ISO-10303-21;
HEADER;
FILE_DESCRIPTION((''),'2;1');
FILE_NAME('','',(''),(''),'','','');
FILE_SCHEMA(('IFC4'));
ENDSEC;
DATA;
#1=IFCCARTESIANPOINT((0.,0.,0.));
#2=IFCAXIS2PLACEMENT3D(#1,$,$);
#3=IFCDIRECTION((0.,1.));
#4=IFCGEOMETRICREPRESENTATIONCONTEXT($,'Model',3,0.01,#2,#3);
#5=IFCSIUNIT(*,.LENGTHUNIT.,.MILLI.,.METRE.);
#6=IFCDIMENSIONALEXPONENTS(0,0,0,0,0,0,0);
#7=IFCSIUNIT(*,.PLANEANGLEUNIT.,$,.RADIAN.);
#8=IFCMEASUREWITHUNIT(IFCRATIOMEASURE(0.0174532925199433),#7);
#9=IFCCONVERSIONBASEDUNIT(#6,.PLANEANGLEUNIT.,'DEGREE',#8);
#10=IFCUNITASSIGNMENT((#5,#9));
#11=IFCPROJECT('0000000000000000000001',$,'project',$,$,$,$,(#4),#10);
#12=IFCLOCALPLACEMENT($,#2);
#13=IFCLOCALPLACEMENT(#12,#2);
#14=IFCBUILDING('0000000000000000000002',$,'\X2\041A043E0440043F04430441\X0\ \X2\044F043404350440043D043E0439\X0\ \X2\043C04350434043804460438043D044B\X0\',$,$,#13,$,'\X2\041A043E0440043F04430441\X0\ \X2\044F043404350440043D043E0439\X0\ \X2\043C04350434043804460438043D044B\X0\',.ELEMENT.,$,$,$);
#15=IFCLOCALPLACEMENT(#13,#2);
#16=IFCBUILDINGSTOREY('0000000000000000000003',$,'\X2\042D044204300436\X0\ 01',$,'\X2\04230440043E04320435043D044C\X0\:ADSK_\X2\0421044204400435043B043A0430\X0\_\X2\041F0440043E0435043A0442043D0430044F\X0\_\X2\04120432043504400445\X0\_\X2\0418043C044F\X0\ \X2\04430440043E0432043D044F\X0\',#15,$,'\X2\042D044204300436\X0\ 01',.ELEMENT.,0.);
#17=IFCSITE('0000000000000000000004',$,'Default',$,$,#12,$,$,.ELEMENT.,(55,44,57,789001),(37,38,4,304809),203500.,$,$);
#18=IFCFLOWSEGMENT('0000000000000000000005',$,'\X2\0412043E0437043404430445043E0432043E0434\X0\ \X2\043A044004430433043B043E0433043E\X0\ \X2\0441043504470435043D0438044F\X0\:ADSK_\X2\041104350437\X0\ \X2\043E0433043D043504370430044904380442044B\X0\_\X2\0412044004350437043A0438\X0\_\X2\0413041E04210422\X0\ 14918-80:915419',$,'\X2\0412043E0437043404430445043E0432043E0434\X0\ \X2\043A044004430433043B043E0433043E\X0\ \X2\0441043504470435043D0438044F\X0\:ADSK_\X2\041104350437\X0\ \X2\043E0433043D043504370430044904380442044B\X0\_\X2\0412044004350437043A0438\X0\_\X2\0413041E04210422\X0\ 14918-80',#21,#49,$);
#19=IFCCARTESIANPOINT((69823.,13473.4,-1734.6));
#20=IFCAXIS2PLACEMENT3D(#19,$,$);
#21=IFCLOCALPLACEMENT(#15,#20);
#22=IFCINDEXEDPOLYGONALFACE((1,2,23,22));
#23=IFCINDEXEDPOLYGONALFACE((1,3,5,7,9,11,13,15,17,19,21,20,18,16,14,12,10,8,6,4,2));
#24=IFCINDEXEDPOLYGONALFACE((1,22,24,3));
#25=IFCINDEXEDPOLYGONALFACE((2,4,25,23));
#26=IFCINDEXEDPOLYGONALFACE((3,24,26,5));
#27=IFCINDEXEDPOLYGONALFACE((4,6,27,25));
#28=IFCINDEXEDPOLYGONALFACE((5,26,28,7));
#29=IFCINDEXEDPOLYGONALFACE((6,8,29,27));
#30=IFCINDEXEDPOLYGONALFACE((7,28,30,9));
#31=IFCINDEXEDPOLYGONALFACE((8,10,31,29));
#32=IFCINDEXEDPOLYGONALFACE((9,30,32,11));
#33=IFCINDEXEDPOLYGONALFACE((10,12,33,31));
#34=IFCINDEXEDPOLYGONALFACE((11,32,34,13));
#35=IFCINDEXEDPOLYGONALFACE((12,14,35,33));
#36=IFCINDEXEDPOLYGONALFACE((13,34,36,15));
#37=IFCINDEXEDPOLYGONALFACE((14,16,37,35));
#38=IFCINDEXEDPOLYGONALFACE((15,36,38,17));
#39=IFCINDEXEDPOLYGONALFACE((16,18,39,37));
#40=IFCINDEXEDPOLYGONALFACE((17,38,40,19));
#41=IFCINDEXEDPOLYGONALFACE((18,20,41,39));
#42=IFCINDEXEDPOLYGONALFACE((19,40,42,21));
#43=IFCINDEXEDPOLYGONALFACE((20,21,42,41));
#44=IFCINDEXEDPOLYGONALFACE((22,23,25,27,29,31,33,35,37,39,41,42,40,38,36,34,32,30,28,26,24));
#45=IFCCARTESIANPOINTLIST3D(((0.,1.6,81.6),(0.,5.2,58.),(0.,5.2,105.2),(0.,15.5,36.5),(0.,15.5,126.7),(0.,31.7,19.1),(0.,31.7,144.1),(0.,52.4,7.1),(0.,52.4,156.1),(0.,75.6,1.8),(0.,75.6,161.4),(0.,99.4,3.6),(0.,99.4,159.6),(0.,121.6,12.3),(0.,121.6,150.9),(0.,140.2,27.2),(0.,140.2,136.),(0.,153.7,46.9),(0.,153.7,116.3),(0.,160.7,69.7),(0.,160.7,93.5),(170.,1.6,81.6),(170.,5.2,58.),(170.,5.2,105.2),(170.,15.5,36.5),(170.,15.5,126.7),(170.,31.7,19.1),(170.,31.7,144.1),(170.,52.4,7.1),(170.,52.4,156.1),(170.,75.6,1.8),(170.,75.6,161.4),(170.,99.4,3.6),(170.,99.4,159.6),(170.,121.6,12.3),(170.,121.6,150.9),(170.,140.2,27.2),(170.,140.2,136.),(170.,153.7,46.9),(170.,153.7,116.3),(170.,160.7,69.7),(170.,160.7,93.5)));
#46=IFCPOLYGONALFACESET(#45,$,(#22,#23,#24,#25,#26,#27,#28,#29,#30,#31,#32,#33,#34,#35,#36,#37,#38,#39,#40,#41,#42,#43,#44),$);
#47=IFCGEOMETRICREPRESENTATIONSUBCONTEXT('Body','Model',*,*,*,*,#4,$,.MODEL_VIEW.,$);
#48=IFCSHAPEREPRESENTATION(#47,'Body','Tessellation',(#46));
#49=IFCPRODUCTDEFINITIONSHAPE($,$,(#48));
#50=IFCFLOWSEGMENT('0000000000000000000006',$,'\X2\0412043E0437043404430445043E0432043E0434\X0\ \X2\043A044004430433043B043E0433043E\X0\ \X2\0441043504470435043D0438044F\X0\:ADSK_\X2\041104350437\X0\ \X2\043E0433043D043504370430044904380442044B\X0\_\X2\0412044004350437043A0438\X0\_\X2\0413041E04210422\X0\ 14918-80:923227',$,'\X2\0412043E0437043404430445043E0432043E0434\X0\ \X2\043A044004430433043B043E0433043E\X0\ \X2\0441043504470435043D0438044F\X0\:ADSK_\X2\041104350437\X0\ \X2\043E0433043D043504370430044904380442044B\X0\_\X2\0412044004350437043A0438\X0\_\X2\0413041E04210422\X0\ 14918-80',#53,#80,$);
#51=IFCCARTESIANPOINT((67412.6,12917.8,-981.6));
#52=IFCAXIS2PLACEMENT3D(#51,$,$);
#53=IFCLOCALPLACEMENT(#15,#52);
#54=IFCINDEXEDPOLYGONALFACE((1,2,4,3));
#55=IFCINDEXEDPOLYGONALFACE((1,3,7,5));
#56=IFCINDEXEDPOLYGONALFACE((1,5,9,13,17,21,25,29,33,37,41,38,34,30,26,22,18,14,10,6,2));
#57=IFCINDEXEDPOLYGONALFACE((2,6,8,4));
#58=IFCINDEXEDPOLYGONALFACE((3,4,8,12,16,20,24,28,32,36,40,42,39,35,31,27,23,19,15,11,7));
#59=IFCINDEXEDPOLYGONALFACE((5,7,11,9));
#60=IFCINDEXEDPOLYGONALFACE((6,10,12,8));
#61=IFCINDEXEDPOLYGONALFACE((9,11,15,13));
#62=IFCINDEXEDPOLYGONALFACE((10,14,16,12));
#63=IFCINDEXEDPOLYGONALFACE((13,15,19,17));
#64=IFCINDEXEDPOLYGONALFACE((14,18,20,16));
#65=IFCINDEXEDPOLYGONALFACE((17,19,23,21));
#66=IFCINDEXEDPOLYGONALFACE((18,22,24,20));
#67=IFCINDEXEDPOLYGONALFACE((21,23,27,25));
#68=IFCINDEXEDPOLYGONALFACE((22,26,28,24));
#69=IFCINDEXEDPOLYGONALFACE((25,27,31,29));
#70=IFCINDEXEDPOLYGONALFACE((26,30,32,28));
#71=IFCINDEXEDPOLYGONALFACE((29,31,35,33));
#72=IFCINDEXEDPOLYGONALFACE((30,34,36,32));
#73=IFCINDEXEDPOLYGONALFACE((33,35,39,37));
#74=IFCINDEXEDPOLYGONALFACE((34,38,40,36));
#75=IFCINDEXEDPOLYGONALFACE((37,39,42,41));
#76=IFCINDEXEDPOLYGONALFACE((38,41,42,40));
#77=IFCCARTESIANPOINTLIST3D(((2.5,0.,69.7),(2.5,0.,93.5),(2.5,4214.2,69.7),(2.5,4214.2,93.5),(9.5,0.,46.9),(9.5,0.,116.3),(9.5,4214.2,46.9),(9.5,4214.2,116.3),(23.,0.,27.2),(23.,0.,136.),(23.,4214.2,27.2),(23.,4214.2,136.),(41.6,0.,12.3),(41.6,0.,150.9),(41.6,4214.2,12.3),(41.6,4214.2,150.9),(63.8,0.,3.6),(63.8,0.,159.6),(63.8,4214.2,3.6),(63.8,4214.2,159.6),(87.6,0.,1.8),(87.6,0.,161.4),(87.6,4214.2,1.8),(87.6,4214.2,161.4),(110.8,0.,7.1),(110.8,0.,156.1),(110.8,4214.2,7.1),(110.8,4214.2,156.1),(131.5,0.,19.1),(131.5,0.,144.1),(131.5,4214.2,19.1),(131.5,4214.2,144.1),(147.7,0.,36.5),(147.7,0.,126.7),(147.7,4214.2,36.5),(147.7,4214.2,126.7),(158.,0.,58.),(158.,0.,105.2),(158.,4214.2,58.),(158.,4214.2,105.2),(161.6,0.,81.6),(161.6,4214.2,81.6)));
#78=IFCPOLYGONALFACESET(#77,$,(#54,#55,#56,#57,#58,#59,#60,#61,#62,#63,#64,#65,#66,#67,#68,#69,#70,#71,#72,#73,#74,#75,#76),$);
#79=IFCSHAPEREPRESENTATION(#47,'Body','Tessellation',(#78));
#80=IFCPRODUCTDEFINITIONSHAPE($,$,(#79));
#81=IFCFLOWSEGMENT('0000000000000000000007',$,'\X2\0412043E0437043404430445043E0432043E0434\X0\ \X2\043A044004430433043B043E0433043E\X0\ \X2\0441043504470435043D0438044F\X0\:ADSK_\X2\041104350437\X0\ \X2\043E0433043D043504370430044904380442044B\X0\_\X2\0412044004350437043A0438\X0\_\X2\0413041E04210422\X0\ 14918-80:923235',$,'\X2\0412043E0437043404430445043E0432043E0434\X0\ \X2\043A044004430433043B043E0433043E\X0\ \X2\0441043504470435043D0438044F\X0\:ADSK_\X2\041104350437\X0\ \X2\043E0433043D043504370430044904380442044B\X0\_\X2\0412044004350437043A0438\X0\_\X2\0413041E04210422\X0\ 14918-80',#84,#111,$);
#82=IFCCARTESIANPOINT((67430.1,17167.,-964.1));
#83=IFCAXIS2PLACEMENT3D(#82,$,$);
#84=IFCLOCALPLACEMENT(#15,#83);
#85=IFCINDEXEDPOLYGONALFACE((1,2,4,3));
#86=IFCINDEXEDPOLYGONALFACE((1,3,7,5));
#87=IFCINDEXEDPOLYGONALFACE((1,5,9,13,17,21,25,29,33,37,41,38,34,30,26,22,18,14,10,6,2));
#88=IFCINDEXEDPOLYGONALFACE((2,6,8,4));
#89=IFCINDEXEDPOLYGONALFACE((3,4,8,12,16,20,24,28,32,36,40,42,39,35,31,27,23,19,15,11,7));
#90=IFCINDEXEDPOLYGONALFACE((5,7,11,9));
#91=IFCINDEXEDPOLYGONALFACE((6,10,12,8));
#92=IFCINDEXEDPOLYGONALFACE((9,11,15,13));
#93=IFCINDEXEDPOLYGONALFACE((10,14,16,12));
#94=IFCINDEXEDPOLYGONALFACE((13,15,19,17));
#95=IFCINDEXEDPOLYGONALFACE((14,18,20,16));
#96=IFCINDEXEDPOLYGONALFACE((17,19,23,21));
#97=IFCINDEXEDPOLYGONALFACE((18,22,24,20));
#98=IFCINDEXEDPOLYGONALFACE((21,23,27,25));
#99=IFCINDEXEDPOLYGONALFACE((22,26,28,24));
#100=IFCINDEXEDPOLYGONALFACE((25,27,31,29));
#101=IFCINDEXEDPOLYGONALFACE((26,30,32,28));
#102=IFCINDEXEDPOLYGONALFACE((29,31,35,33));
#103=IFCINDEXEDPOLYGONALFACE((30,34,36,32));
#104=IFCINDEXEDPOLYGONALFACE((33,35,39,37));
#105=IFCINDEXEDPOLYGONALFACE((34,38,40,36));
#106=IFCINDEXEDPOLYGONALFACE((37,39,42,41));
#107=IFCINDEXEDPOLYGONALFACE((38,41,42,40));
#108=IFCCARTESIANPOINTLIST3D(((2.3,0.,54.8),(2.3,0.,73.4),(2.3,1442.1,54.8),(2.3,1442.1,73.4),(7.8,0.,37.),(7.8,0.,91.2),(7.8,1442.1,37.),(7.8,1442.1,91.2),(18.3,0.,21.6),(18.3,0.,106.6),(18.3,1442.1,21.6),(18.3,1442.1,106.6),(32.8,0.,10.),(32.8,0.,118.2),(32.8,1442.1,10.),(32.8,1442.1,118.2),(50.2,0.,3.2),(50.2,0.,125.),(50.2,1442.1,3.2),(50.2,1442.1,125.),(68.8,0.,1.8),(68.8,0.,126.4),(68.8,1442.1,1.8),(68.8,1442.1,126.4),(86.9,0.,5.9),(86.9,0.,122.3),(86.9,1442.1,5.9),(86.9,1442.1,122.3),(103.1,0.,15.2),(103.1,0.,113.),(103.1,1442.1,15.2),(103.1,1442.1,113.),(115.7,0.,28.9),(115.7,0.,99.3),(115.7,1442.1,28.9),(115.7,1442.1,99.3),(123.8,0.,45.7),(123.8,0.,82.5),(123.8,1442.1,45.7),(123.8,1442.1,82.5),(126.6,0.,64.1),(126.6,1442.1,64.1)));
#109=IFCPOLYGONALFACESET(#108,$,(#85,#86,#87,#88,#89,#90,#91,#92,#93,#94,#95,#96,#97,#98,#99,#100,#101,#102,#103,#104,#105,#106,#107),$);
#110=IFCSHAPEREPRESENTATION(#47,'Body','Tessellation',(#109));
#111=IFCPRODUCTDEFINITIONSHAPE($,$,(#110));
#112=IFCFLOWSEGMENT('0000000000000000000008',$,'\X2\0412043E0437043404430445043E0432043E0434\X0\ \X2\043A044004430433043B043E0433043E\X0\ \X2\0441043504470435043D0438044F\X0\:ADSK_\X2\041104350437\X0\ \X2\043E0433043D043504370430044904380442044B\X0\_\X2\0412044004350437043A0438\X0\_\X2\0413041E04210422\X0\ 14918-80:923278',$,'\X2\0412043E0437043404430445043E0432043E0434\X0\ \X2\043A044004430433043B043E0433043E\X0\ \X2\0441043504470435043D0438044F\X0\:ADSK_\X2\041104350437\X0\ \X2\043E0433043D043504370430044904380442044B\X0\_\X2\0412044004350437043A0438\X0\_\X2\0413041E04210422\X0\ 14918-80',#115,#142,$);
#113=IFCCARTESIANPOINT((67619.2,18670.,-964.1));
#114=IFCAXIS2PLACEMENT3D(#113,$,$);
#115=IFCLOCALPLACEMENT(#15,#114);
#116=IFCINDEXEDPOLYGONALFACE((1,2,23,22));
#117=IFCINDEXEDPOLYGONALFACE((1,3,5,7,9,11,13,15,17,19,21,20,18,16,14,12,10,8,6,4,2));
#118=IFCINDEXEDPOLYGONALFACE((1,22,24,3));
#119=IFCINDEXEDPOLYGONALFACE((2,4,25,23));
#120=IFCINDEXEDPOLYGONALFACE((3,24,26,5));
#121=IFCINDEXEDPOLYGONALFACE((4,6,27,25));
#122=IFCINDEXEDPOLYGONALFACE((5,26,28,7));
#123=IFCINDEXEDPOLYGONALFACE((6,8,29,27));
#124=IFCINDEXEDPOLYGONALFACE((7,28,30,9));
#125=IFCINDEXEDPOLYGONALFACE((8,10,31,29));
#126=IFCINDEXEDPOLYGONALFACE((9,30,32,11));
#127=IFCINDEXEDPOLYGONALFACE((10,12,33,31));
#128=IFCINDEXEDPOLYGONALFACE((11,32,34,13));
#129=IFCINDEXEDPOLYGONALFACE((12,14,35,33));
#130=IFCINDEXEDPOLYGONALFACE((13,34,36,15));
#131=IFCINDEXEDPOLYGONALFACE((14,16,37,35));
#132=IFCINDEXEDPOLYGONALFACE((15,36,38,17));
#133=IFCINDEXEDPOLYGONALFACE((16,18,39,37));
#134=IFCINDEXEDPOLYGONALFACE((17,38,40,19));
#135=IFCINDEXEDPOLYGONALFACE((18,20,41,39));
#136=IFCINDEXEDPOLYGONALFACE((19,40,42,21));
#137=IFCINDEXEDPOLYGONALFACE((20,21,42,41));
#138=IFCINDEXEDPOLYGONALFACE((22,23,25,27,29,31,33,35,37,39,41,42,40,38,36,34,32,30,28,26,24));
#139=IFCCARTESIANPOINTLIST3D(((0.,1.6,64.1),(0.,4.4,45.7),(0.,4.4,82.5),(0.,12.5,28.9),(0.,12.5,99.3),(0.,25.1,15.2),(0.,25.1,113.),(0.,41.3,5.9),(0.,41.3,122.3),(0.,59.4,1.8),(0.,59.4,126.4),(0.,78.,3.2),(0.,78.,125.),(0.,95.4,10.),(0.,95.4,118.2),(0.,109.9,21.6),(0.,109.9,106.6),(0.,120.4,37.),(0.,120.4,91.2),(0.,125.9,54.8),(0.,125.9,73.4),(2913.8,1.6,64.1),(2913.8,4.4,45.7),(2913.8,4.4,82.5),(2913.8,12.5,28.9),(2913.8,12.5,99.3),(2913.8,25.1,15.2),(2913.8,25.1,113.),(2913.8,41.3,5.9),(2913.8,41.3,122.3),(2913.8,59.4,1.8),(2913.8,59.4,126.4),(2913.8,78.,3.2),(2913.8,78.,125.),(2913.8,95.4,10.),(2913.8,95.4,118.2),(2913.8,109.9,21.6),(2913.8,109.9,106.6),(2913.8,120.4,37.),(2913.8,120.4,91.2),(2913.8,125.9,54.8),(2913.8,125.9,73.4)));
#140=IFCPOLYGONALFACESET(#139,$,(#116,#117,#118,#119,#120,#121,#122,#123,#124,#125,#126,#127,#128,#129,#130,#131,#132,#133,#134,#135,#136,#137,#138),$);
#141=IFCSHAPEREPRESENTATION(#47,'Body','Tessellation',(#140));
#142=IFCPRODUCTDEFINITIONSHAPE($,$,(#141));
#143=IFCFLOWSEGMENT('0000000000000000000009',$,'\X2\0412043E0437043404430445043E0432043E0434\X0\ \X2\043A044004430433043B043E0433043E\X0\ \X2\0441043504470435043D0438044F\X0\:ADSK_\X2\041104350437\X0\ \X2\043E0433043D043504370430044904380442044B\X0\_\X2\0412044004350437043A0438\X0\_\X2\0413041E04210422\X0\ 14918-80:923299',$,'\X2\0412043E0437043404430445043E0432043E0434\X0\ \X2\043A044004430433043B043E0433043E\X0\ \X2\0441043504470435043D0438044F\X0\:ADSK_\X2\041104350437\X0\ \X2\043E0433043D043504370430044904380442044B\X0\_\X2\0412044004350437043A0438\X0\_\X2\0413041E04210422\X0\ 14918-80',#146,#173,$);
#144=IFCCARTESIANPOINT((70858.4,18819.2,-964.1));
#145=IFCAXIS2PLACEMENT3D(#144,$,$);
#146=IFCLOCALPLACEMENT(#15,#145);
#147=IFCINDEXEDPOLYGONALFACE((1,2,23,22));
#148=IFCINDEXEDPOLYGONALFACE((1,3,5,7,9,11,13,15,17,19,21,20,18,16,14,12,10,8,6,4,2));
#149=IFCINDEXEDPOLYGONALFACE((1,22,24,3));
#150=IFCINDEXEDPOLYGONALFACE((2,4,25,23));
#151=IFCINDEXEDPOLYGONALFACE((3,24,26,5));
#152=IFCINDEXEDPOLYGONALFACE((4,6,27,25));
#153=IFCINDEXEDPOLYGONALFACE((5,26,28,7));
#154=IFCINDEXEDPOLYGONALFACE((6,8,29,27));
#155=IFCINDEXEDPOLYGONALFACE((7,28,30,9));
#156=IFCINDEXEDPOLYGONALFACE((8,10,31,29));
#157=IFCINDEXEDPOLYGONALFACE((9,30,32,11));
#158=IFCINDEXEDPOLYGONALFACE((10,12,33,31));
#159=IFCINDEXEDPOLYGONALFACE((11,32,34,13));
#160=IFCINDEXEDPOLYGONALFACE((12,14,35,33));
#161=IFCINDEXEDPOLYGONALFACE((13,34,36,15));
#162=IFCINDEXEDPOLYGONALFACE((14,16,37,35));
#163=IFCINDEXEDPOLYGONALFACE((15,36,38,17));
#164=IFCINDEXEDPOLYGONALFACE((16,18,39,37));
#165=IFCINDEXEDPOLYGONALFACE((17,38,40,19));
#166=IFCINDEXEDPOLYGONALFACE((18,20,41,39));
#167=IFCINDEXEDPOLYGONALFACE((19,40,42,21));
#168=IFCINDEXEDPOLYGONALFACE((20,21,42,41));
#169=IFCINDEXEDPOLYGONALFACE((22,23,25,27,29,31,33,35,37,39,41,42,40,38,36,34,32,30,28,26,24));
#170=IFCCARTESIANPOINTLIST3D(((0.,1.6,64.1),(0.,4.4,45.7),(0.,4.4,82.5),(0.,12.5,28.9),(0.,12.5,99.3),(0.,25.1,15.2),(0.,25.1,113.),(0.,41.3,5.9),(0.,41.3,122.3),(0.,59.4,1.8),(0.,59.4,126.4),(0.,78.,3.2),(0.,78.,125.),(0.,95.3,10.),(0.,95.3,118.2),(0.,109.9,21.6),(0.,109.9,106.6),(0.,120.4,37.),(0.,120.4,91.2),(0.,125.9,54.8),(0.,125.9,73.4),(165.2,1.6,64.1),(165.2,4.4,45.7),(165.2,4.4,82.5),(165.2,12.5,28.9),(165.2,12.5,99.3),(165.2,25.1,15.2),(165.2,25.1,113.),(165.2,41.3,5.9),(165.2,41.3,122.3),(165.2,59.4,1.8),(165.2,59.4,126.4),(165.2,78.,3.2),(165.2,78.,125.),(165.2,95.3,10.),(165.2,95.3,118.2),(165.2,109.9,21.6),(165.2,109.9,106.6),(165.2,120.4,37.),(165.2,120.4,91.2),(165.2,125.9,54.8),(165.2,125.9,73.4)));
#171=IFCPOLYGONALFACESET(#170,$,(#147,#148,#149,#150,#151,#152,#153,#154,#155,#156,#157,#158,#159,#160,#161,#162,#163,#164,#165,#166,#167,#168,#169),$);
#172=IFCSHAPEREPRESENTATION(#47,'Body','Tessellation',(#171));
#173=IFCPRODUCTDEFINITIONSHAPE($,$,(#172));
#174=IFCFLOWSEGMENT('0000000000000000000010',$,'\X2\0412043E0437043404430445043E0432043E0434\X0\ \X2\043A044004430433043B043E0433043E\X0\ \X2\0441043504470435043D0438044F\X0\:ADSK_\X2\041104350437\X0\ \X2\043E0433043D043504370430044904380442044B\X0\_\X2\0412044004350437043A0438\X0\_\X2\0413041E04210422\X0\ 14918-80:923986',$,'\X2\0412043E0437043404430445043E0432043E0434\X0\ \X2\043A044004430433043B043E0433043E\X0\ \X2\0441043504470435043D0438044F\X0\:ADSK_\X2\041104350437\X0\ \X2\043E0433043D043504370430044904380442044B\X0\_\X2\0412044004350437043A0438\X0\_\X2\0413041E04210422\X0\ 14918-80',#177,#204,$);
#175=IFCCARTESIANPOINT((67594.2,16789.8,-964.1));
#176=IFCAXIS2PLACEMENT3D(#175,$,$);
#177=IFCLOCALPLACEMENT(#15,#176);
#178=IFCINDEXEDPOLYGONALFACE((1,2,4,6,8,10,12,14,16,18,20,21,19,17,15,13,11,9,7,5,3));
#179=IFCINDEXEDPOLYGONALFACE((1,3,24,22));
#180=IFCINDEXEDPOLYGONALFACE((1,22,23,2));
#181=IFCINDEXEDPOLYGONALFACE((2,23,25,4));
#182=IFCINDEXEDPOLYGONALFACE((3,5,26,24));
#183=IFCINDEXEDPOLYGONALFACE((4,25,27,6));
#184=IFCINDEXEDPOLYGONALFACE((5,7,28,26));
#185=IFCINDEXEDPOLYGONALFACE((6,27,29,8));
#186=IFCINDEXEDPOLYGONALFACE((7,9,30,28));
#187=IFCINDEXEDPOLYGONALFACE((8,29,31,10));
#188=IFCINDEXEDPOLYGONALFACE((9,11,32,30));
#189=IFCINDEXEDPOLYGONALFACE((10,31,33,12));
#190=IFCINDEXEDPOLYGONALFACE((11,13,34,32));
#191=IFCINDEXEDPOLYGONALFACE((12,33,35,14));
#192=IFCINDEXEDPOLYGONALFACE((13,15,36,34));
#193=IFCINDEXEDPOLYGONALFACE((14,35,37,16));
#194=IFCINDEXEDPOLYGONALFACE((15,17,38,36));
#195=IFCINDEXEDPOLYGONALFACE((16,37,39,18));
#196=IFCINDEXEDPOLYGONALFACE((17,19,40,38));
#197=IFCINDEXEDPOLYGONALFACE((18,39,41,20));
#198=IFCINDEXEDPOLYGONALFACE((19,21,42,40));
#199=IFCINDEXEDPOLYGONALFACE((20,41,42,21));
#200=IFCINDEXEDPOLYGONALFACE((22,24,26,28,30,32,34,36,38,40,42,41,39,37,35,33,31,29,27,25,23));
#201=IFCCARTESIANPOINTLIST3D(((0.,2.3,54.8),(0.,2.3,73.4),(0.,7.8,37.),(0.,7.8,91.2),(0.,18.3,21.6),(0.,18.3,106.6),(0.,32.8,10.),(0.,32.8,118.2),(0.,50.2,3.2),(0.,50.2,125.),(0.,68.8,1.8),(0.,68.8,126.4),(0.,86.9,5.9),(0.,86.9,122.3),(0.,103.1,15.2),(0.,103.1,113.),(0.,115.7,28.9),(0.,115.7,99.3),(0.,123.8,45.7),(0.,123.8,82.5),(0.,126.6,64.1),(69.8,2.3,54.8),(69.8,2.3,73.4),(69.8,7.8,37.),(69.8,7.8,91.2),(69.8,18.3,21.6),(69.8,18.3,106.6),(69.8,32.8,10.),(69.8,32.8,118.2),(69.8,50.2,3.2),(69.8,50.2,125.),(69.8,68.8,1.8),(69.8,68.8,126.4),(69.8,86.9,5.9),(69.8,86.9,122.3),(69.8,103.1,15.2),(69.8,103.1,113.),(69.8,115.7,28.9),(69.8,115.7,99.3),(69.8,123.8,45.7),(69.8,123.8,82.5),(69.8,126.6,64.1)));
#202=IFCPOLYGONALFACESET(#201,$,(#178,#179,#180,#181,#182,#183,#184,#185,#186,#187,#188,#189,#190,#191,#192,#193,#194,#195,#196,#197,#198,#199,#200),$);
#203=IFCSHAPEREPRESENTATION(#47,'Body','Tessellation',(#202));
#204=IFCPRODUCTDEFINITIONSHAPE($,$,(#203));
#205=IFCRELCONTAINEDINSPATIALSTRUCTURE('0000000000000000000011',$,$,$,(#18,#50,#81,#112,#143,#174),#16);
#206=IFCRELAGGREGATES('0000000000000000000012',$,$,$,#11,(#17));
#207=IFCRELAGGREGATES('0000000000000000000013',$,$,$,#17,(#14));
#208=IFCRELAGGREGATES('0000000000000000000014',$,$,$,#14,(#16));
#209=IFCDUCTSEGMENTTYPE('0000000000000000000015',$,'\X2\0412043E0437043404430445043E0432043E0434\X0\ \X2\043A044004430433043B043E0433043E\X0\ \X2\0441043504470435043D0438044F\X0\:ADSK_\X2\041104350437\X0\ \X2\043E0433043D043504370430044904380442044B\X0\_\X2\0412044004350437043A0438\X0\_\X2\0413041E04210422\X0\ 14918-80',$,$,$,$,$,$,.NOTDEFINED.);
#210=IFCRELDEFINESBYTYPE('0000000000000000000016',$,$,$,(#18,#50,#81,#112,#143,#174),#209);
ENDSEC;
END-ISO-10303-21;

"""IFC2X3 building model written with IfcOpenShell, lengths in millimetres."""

from ifc_helpers import new_model, entity, si_unit, converted_unit, direction, frame, origin, origin_2d_with_axis, place, context, subcontext, project, spatial, circle, extrude, type_object, element, save


model = new_model("IFC2X3")

# Units and contexts
model_context = context("Model", 3, precision=0.01, world=origin(), true_north=direction((0.0, 1.0)))
body_context = subcontext(model_context, "Body", "Model", "MODEL_VIEW")
ifc_project = project(units=[si_unit("LENGTHUNIT", "METRE", prefix="MILLI"), converted_unit("PLANEANGLEUNIT", "DEGREE", entity("IfcRatioMeasure", 0.0174532925199433), si_unit("PLANEANGLEUNIT", "RADIAN"), dimensions=[0, 0, 0, 0, 0, 0, 0])], contexts=[model_context])

# Site, building, storey
site_placement = place(None, origin())
site = spatial("IfcSite", under=ifc_project, at=site_placement, Name="Default", CompositionType="ELEMENT", RefLatitude=(55, 44, 57, 789001), RefLongitude=(37, 38, 4, 304809), RefElevation=203500.0)
building_placement = place(site_placement, origin())
building = spatial("IfcBuilding", under=site, at=building_placement, Name="Корпус ядерной медицины", LongName="Корпус ядерной медицины", CompositionType="ELEMENT")
storey_placement = place(building_placement, origin())
storey = spatial("IfcBuildingStorey", under=building, at=storey_placement, Name="Этаж 01", ObjectType="Уровень:ADSK_Стрелка_Проектная_Вверх_Имя уровня", LongName="Этаж 01", CompositionType="ELEMENT", Elevation=0.0)

# Flow segments
duct_segment_type = type_object("IfcDuctSegmentType", Name="Воздуховод круглого сечения:ADSK_Без огнезащиты_Врезки_ГОСТ 14918-80", PredefinedType="NOTDEFINED")
flow_segment_1_placement = place(storey_placement, frame((69823.0, 13473.4, -1734.6)))
element("IfcFlowSegment", 1, at=flow_segment_1_placement, inside=storey, type_object=duct_segment_type, Name="Воздуховод круглого сечения:ADSK_Без огнезащиты_Врезки_ГОСТ 14918-80:915419", ObjectType="Воздуховод круглого сечения:ADSK_Без огнезащиты_Врезки_ГОСТ 14918-80", context=body_context, shape_type="SweptSolid", body=[
    extrude(circle(Radius=80.0, at=origin_2d_with_axis()), frame((0.0, 81.6, 81.6), z_axis=(1.0, 0.0, 0.0), x_axis=(0.0, -1.0, 0.0)), (0.0, 0.0, 1.0), 170.0),
])
flow_segment_2_placement = place(storey_placement, frame((67412.6, 12917.8, -981.6)))
element("IfcFlowSegment", 2, at=flow_segment_2_placement, inside=storey, type_object=duct_segment_type, Name="Воздуховод круглого сечения:ADSK_Без огнезащиты_Врезки_ГОСТ 14918-80:923227", ObjectType="Воздуховод круглого сечения:ADSK_Без огнезащиты_Врезки_ГОСТ 14918-80", context=body_context, shape_type="SweptSolid", body=[
    extrude(circle(Radius=80.0, at=origin_2d_with_axis()), frame((81.6, 0.0, 81.6), z_axis=(0.0, 1.0, 0.0), x_axis=(1.0, 0.0, 0.0)), (0.0, 0.0, 1.0), 4214.2),
])
flow_segment_3_placement = place(storey_placement, frame((67430.1, 17167.0, -964.1)))
element("IfcFlowSegment", 3, at=flow_segment_3_placement, inside=storey, type_object=duct_segment_type, Name="Воздуховод круглого сечения:ADSK_Без огнезащиты_Врезки_ГОСТ 14918-80:923235", ObjectType="Воздуховод круглого сечения:ADSK_Без огнезащиты_Врезки_ГОСТ 14918-80", context=body_context, shape_type="SweptSolid", body=[
    extrude(circle(Radius=62.5, at=origin_2d_with_axis()), frame((64.1, 0.0, 64.1), z_axis=(0.0, 1.0, 0.0), x_axis=(1.0, 0.0, 0.0)), (0.0, 0.0, 1.0), 1442.1),
])
flow_segment_4_placement = place(storey_placement, frame((67619.2, 18670.0, -964.1)))
element("IfcFlowSegment", 4, at=flow_segment_4_placement, inside=storey, type_object=duct_segment_type, Name="Воздуховод круглого сечения:ADSK_Без огнезащиты_Врезки_ГОСТ 14918-80:923278", ObjectType="Воздуховод круглого сечения:ADSK_Без огнезащиты_Врезки_ГОСТ 14918-80", context=body_context, shape_type="SweptSolid", body=[
    extrude(circle(Radius=62.5, at=origin_2d_with_axis()), frame((0.0, 64.1, 64.1), z_axis=(1.0, 0.0, 0.0), x_axis=(0.0, -1.0, 0.0)), (0.0, 0.0, 1.0), 2913.8),
])
flow_segment_5_placement = place(storey_placement, frame((70858.4, 18819.2, -964.1)))
element("IfcFlowSegment", 5, at=flow_segment_5_placement, inside=storey, type_object=duct_segment_type, Name="Воздуховод круглого сечения:ADSK_Без огнезащиты_Врезки_ГОСТ 14918-80:923299", ObjectType="Воздуховод круглого сечения:ADSK_Без огнезащиты_Врезки_ГОСТ 14918-80", context=body_context, shape_type="SweptSolid", body=[
    extrude(circle(Radius=62.5, at=origin_2d_with_axis()), frame((0.0, 64.1, 64.1), z_axis=(1.0, 0.0, 0.0), x_axis=(0.0, -1.0, 0.0)), (0.0, 0.0, 1.0), 165.2),
])
flow_segment_6_placement = place(storey_placement, frame((67594.2, 16789.8, -964.1)))
element("IfcFlowSegment", 6, at=flow_segment_6_placement, inside=storey, type_object=duct_segment_type, Name="Воздуховод круглого сечения:ADSK_Без огнезащиты_Врезки_ГОСТ 14918-80:923986", ObjectType="Воздуховод круглого сечения:ADSK_Без огнезащиты_Врезки_ГОСТ 14918-80", context=body_context, shape_type="SweptSolid", body=[
    extrude(circle(Radius=62.5, at=origin_2d_with_axis()), frame((0.0, 64.1, 64.1), z_axis=(1.0, 0.0, 0.0), x_axis=(0.0, 1.0, 0.0)), (0.0, 0.0, 1.0), 69.8),
])

save(model, "model.ifc")
